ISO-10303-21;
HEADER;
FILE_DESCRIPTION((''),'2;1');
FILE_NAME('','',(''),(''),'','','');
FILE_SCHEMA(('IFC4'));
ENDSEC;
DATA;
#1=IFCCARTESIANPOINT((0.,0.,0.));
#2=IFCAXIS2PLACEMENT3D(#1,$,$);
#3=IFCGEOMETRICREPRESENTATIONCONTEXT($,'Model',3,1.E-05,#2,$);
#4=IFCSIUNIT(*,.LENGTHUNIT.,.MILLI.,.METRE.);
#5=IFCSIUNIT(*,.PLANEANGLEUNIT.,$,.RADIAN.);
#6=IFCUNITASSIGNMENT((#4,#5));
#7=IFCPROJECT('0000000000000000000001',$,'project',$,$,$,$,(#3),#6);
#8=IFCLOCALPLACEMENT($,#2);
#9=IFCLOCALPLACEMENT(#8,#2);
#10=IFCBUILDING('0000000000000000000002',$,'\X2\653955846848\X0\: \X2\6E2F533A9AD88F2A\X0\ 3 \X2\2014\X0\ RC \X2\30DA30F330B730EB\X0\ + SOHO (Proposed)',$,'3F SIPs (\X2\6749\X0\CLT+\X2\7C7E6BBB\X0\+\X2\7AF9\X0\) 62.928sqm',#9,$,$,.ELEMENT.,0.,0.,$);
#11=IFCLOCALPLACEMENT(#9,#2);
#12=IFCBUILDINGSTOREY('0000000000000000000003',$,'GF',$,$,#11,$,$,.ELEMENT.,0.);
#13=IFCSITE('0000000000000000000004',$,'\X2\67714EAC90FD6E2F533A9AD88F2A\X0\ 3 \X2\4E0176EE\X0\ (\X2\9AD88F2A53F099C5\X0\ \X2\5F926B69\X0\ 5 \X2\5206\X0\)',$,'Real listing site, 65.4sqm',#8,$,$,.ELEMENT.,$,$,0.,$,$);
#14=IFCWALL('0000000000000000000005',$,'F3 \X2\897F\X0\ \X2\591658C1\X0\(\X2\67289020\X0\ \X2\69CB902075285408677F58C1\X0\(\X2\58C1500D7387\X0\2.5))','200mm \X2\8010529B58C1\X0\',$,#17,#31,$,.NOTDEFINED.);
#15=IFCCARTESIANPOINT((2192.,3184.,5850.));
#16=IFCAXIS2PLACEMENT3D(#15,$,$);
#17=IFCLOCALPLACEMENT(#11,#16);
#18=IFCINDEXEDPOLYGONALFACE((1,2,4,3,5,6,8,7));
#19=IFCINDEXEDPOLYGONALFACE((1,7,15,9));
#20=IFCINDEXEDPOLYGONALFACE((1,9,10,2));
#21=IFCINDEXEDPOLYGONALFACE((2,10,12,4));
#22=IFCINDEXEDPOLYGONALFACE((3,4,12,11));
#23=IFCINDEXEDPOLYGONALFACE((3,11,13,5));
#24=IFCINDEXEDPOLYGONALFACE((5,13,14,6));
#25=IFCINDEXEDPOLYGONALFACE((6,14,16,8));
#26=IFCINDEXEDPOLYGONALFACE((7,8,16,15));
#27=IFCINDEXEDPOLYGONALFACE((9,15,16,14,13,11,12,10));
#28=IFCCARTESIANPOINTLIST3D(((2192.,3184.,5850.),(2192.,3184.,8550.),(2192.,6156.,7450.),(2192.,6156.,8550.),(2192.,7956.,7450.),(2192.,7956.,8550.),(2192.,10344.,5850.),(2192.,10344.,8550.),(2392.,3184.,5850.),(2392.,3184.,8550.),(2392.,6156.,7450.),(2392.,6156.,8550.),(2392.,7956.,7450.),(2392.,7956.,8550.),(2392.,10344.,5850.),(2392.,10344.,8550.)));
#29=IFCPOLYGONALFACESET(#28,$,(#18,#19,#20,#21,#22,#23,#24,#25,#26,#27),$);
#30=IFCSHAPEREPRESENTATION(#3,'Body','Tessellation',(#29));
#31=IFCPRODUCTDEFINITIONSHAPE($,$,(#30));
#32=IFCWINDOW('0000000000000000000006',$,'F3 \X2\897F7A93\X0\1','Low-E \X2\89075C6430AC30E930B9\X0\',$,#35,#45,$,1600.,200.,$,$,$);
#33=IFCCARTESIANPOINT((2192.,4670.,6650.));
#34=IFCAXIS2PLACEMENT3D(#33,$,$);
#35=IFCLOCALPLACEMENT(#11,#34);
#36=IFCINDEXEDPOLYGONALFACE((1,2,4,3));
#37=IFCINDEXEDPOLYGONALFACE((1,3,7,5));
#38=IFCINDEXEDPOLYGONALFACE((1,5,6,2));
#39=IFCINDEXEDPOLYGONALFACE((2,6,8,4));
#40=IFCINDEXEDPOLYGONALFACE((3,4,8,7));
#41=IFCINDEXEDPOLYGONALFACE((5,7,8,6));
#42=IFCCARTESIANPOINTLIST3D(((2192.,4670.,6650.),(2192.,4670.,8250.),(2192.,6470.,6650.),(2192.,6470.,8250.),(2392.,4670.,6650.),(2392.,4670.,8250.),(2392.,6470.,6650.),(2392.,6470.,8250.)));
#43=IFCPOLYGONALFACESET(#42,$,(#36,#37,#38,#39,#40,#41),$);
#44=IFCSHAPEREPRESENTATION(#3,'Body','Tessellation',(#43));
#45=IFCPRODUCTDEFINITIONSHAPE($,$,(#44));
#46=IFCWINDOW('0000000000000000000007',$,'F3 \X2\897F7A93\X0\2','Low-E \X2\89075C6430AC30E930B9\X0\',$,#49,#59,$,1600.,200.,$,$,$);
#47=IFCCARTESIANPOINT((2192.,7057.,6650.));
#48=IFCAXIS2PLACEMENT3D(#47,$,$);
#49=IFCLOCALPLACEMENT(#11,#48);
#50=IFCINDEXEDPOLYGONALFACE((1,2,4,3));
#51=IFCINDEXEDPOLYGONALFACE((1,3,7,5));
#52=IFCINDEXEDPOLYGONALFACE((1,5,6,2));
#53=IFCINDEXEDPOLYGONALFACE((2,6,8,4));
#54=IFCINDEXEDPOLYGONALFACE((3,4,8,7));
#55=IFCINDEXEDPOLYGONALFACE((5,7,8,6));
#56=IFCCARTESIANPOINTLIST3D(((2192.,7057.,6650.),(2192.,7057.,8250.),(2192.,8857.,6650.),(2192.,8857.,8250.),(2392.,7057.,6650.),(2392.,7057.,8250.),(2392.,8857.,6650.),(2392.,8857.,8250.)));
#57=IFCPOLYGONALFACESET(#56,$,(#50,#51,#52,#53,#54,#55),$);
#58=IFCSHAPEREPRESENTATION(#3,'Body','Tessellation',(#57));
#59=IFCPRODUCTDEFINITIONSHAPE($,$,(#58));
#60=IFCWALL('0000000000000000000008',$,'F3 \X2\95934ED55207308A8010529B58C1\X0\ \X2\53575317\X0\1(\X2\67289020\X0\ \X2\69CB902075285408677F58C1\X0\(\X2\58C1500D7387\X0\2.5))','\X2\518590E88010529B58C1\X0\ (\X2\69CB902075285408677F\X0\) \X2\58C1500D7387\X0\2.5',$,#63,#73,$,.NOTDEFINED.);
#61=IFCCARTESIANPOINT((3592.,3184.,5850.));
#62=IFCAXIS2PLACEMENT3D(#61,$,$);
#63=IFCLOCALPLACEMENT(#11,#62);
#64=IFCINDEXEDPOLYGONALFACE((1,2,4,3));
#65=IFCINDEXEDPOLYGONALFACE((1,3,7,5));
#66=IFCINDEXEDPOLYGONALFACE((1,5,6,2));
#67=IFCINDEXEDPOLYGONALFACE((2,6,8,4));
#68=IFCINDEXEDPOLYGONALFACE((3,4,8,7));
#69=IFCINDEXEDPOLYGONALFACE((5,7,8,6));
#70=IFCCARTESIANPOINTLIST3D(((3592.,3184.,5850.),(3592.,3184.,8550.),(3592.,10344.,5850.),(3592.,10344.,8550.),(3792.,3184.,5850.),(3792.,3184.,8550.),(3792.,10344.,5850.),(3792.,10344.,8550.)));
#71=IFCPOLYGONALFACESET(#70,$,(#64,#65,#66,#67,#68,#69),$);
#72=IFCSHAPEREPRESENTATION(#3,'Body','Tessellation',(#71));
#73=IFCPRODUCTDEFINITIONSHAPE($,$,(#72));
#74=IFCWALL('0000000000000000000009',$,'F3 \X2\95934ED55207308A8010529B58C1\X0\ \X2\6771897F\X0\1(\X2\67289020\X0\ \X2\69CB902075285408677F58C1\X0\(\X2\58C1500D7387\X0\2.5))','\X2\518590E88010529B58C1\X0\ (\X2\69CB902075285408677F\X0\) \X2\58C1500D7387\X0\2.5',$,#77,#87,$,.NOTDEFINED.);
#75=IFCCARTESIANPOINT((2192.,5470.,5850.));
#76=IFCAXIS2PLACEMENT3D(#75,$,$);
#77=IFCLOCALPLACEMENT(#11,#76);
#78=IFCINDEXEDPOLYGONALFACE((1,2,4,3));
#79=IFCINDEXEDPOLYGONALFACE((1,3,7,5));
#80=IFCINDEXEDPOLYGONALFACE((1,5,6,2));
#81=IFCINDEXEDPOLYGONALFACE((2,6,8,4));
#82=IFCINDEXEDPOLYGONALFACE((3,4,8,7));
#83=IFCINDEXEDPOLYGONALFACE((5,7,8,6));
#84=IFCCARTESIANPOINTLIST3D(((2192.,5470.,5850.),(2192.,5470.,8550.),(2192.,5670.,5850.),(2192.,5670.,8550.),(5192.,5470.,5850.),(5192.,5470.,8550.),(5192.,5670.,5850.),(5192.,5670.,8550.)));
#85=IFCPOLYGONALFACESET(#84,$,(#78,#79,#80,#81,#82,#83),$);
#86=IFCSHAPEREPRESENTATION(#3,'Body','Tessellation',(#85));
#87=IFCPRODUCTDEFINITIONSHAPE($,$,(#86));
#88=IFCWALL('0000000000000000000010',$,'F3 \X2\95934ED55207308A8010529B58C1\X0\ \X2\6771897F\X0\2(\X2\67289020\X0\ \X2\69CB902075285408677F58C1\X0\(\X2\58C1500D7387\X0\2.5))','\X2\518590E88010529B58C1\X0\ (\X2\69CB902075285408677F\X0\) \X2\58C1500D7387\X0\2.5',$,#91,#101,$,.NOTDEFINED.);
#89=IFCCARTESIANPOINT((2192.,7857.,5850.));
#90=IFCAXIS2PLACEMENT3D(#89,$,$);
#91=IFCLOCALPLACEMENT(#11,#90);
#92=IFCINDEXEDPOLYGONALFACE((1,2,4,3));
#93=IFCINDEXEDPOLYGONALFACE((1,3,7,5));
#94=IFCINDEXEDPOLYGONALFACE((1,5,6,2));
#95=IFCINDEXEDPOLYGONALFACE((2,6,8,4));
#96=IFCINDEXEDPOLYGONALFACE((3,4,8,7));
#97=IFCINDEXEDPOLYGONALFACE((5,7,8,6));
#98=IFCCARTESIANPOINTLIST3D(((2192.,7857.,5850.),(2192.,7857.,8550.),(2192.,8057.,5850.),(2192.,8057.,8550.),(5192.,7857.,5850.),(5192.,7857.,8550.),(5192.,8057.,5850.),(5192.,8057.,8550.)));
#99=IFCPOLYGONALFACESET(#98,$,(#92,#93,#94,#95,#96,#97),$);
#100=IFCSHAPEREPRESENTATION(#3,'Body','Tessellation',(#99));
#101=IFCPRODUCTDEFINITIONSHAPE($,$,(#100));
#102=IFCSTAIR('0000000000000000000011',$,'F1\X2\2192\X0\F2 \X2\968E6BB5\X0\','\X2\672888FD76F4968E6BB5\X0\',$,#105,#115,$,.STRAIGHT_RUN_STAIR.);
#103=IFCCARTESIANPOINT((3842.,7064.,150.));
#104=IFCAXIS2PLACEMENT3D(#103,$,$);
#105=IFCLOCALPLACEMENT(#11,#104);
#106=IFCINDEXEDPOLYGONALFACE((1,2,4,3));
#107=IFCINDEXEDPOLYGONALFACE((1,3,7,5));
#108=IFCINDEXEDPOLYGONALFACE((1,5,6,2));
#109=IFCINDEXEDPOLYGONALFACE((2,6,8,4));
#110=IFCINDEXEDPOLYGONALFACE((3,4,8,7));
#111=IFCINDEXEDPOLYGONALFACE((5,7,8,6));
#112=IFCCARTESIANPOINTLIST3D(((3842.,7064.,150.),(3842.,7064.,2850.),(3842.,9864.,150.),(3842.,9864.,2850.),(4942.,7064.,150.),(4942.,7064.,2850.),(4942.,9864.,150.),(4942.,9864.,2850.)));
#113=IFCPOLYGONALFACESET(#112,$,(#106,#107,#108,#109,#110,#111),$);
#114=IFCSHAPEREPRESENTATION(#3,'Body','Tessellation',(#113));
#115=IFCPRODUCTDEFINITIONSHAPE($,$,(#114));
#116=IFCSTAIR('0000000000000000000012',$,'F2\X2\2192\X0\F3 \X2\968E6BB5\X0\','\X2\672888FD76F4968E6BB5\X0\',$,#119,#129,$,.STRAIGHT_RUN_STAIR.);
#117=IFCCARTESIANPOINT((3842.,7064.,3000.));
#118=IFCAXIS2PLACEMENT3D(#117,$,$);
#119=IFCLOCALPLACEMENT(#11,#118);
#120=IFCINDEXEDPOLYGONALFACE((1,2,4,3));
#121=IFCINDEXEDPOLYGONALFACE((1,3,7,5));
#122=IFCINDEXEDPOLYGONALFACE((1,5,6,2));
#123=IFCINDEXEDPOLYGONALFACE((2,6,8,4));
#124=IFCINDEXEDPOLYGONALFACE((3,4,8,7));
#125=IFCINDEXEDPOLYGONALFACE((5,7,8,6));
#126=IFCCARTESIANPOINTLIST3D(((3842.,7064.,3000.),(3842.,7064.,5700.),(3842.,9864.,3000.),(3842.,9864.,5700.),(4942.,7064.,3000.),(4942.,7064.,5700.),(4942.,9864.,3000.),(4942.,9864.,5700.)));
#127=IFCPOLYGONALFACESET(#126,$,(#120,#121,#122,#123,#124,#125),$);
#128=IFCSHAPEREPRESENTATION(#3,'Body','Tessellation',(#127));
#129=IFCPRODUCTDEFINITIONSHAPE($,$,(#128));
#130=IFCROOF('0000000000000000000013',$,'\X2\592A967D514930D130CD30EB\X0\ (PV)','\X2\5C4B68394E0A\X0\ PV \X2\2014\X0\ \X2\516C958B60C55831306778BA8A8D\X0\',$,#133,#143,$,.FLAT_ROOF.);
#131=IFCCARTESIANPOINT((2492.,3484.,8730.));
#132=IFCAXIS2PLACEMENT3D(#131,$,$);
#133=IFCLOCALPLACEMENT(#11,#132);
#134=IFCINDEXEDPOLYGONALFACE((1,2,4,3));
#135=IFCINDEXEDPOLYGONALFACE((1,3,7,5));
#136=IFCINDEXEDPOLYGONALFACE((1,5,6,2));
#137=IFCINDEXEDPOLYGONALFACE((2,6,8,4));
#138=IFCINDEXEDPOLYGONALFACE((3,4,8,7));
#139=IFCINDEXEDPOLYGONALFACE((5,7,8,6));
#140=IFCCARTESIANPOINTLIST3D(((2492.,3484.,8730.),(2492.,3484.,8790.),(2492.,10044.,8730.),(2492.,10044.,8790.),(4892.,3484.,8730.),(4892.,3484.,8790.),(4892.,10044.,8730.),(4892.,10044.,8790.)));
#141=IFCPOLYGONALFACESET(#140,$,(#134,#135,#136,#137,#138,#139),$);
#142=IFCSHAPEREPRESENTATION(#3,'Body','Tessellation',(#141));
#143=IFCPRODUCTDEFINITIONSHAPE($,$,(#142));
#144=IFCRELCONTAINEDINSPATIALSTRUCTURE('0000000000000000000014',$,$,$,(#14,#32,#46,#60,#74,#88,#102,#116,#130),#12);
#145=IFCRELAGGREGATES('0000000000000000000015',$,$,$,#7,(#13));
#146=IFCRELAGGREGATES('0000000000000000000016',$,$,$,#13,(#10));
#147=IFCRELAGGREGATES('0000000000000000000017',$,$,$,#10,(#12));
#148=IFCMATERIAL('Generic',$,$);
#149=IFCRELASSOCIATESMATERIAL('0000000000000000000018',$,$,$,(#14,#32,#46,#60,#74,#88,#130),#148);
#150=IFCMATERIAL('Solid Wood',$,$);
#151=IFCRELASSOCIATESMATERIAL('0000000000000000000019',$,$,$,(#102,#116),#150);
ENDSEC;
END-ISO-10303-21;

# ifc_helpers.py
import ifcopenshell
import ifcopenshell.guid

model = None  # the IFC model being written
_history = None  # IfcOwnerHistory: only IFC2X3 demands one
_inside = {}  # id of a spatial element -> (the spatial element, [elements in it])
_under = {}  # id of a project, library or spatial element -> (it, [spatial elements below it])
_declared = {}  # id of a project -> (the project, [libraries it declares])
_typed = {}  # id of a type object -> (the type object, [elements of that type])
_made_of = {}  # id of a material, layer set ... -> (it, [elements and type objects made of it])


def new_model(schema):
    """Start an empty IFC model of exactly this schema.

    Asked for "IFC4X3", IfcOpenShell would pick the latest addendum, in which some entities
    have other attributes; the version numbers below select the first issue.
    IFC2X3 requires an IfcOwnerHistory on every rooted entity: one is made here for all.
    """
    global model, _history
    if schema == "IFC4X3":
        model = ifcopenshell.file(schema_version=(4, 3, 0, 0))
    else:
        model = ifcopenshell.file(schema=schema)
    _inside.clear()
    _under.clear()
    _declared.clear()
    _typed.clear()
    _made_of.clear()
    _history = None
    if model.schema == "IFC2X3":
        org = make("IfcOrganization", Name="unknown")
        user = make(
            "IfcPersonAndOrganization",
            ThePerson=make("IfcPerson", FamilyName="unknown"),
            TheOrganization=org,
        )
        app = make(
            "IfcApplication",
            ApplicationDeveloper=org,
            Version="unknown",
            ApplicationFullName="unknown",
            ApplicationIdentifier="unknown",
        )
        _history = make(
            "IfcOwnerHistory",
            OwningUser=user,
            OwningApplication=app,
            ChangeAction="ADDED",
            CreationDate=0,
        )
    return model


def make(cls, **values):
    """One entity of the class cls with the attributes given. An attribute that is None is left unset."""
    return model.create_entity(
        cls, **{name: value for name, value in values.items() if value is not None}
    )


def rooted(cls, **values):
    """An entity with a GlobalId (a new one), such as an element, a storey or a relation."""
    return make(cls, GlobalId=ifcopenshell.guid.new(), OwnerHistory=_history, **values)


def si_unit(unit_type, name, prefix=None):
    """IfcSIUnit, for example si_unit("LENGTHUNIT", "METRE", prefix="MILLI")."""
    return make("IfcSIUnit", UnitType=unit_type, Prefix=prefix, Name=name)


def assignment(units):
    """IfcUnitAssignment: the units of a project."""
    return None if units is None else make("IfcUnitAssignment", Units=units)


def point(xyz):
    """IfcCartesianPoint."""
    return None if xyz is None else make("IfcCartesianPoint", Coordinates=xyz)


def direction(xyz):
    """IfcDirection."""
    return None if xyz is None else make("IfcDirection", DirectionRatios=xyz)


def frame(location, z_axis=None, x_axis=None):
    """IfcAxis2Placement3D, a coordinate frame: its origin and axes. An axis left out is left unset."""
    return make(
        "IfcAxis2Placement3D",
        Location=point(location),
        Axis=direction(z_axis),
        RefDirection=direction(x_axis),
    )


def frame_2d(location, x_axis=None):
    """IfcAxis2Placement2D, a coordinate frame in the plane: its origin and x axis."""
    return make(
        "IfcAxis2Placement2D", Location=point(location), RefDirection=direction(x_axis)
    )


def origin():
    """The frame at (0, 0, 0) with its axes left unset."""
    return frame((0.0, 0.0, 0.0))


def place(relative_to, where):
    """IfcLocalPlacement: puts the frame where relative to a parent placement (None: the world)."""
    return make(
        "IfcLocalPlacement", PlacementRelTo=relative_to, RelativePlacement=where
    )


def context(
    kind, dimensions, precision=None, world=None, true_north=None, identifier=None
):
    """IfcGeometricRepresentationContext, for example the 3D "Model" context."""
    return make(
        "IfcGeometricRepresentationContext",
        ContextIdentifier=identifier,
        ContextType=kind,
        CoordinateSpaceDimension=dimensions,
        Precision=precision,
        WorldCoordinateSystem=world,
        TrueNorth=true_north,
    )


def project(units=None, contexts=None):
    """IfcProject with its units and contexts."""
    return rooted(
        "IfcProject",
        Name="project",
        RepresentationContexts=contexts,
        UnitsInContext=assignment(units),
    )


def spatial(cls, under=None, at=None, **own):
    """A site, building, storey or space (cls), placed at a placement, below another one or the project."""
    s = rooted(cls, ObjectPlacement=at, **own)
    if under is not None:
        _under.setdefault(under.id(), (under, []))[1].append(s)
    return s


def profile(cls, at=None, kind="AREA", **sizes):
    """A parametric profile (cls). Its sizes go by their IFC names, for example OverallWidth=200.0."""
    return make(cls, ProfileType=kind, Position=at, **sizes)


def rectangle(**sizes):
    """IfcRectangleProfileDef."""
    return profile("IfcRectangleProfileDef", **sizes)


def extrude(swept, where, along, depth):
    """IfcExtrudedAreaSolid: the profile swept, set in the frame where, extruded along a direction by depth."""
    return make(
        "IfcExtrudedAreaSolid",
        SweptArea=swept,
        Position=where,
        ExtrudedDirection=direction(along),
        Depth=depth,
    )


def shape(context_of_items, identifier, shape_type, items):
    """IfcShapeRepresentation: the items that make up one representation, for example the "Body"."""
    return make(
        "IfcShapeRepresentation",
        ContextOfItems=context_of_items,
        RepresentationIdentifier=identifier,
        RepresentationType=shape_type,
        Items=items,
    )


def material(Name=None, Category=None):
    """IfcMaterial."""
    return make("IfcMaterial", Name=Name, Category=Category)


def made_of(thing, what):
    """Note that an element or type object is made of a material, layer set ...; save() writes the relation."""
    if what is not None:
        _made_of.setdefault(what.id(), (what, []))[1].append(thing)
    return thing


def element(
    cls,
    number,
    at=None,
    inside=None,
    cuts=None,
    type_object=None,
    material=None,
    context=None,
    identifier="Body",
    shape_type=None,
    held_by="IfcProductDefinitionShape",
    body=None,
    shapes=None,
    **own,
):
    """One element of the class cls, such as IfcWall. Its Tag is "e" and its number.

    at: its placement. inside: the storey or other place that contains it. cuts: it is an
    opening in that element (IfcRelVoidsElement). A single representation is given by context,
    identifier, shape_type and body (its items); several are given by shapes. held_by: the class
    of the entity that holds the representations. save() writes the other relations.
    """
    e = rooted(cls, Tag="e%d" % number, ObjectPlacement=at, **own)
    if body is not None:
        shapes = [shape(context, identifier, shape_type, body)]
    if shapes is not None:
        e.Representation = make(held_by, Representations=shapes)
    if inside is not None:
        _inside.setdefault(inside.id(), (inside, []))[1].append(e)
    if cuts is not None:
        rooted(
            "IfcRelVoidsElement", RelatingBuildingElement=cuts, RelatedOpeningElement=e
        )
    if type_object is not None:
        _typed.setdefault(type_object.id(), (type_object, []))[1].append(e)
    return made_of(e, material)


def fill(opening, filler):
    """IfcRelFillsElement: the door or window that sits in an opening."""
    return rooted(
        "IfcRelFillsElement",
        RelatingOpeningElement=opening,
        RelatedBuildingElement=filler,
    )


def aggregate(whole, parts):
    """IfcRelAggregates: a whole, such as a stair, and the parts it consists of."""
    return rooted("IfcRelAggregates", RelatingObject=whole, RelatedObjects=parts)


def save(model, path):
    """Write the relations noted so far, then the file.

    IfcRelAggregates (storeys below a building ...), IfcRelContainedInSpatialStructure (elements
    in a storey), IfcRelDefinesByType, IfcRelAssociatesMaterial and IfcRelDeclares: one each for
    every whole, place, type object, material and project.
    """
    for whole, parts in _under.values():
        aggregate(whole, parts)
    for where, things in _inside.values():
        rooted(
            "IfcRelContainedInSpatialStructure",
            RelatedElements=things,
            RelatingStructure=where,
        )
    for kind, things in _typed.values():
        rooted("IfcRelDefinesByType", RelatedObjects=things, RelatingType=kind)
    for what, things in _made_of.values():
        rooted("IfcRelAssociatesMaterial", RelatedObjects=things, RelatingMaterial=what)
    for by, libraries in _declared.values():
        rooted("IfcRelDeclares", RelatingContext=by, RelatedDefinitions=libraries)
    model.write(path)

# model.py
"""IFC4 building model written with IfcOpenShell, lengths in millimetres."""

from ifc_helpers import new_model, si_unit, frame, frame_2d, origin, place, context, project, spatial, rectangle, extrude, material, element, fill, save


model = new_model("IFC4")

# Units and contexts
model_context = context("Model", 3, precision=1e-05, world=origin())
ifc_project = project(units=[si_unit("LENGTHUNIT", "METRE", prefix="MILLI"), si_unit("PLANEANGLEUNIT", "RADIAN")], contexts=[model_context])

# Site, building, storey
site_placement = place(None, origin())
site = spatial("IfcSite", under=ifc_project, at=site_placement, Name="東京都港区高輪 3 丁目 (高輪台駅 徒歩 5 分)", ObjectType="Real listing site, 65.4sqm", CompositionType="ELEMENT", RefElevation=0.0)
building_placement = place(site_placement, origin())
building = spatial("IfcBuilding", under=site, at=building_placement, Name="改善案: 港区高輪 3 — RC ペンシル + SOHO (Proposed)", ObjectType="3F SIPs (杉CLT+籾殻+竹) 62.928sqm", CompositionType="ELEMENT", ElevationOfRefHeight=0.0, ElevationOfTerrain=0.0)
storey_placement = place(building_placement, origin())
storey = spatial("IfcBuildingStorey", under=building, at=storey_placement, Name="GF", CompositionType="ELEMENT", Elevation=0.0)

# Shared definitions
ifc_material_1 = material(Name="Generic")

# Wall, openings, windows
wall_1_placement = place(storey_placement, frame((2192.0, 3184.0, 5850.0)))
wall_1 = element("IfcWall", 1, at=wall_1_placement, inside=storey, material=ifc_material_1, Name="F3 西 外壁(木造 構造用合板壁(壁倍率2.5))", Description="200mm 耐力壁", PredefinedType="NOTDEFINED", context=model_context, shape_type="SweptSolid", body=[
    extrude(rectangle(XDim=200.0, YDim=7160.0, at=frame_2d((100.0, 3580.0))), frame((2192.0, 3184.0, 5850.0)), (0.0, 0.0, 1.0), 2700.0),
])
opening_1_placement = place(storey_placement, frame((2192.0, 4670.0, 6650.0)))
opening_1 = element("IfcOpeningElement", 2, at=opening_1_placement, cuts=wall_1, PredefinedType="NOTDEFINED", context=model_context, shape_type="SweptSolid", body=[
    extrude(rectangle(XDim=200.0, YDim=1800.0, at=frame_2d((100.0, 900.0))), frame((2192.0, 4670.0, 6650.0)), (0.0, 0.0, 1.0), 1600.0),
])
opening_2_placement = place(storey_placement, frame((2192.0, 7057.0, 6650.0)))
opening_2 = element("IfcOpeningElement", 3, at=opening_2_placement, cuts=wall_1, PredefinedType="NOTDEFINED", context=model_context, shape_type="SweptSolid", body=[
    extrude(rectangle(XDim=200.0, YDim=1800.0, at=frame_2d((100.0, 900.0))), frame((2192.0, 7057.0, 6650.0)), (0.0, 0.0, 1.0), 1600.0),
])
window_1_placement = place(storey_placement, frame((2192.0, 4670.0, 6650.0)))
window_1 = element("IfcWindow", 4, at=window_1_placement, inside=storey, material=ifc_material_1, Name="F3 西窓1", Description="Low-E 複層ガラス", OverallHeight=1600.0, OverallWidth=200.0, context=model_context, shape_type="SweptSolid", body=[
    extrude(rectangle(XDim=200.0, YDim=1800.0, at=frame_2d((100.0, 900.0))), frame((2192.0, 4670.0, 6650.0)), (0.0, 0.0, 1.0), 1600.0),
])
fill(opening_1, window_1)
window_2_placement = place(storey_placement, frame((2192.0, 7057.0, 6650.0)))
window_2 = element("IfcWindow", 5, at=window_2_placement, inside=storey, material=ifc_material_1, Name="F3 西窓2", Description="Low-E 複層ガラス", OverallHeight=1600.0, OverallWidth=200.0, context=model_context, shape_type="SweptSolid", body=[
    extrude(rectangle(XDim=200.0, YDim=1800.0, at=frame_2d((100.0, 900.0))), frame((2192.0, 7057.0, 6650.0)), (0.0, 0.0, 1.0), 1600.0),
])
fill(opening_2, window_2)

# Walls
wall_2_placement = place(storey_placement, frame((3592.0, 3184.0, 5850.0)))
element("IfcWall", 6, at=wall_2_placement, inside=storey, material=ifc_material_1, Name="F3 間仕切り耐力壁 南北1(木造 構造用合板壁(壁倍率2.5))", Description="内部耐力壁 (構造用合板) 壁倍率2.5", PredefinedType="NOTDEFINED", context=model_context, shape_type="SweptSolid", body=[
    extrude(rectangle(XDim=200.0, YDim=7160.0, at=frame_2d((100.0, 3580.0))), frame((3592.0, 3184.0, 5850.0)), (0.0, 0.0, 1.0), 2700.0),
])
wall_3_placement = place(storey_placement, frame((2192.0, 5470.0, 5850.0)))
element("IfcWall", 7, at=wall_3_placement, inside=storey, material=ifc_material_1, Name="F3 間仕切り耐力壁 東西1(木造 構造用合板壁(壁倍率2.5))", Description="内部耐力壁 (構造用合板) 壁倍率2.5", PredefinedType="NOTDEFINED", context=model_context, shape_type="SweptSolid", body=[
    extrude(rectangle(XDim=3000.0, YDim=200.0, at=frame_2d((1500.0, 100.0))), frame((2192.0, 5470.0, 5850.0)), (0.0, 0.0, 1.0), 2700.0),
])
wall_4_placement = place(storey_placement, frame((2192.0, 7857.0, 5850.0)))
element("IfcWall", 8, at=wall_4_placement, inside=storey, material=ifc_material_1, Name="F3 間仕切り耐力壁 東西2(木造 構造用合板壁(壁倍率2.5))", Description="内部耐力壁 (構造用合板) 壁倍率2.5", PredefinedType="NOTDEFINED", context=model_context, shape_type="SweptSolid", body=[
    extrude(rectangle(XDim=3000.0, YDim=200.0, at=frame_2d((1500.0, 100.0))), frame((2192.0, 7857.0, 5850.0)), (0.0, 0.0, 1.0), 2700.0),
])

# Stairs
ifc_material_2 = material(Name="Solid Wood")
stair_1_placement = place(storey_placement, frame((3842.0, 7064.0, 150.0)))
element("IfcStair", 9, at=stair_1_placement, inside=storey, material=ifc_material_2, Name="F1→F2 階段", Description="木製直階段", PredefinedType="STRAIGHT_RUN_STAIR", context=model_context, shape_type="SweptSolid", body=[
    extrude(rectangle(XDim=1100.0, YDim=2800.0, at=frame_2d((550.0, 1400.0))), frame((3842.0, 7064.0, 150.0)), (0.0, 0.0, 1.0), 2700.0),
])
stair_2_placement = place(storey_placement, frame((3842.0, 7064.0, 3000.0)))
element("IfcStair", 10, at=stair_2_placement, inside=storey, material=ifc_material_2, Name="F2→F3 階段", Description="木製直階段", PredefinedType="STRAIGHT_RUN_STAIR", context=model_context, shape_type="SweptSolid", body=[
    extrude(rectangle(XDim=1100.0, YDim=2800.0, at=frame_2d((550.0, 1400.0))), frame((3842.0, 7064.0, 3000.0)), (0.0, 0.0, 1.0), 2700.0),
])

# Roof
roof_placement = place(storey_placement, frame((2492.0, 3484.0, 8730.0)))
element("IfcRoof", 11, at=roof_placement, inside=storey, material=ifc_material_1, Name="太陽光パネル (PV)", Description="屋根上 PV — 公開情報で確認", PredefinedType="FLAT_ROOF", context=model_context, shape_type="SweptSolid", body=[
    extrude(rectangle(XDim=2400.0, YDim=6560.0, at=frame_2d((1200.0, 3280.0))), frame((2492.0, 3484.0, 8730.0)), (0.0, 0.0, 1.0), 60.0),
])

save(model, "model.ifc")
